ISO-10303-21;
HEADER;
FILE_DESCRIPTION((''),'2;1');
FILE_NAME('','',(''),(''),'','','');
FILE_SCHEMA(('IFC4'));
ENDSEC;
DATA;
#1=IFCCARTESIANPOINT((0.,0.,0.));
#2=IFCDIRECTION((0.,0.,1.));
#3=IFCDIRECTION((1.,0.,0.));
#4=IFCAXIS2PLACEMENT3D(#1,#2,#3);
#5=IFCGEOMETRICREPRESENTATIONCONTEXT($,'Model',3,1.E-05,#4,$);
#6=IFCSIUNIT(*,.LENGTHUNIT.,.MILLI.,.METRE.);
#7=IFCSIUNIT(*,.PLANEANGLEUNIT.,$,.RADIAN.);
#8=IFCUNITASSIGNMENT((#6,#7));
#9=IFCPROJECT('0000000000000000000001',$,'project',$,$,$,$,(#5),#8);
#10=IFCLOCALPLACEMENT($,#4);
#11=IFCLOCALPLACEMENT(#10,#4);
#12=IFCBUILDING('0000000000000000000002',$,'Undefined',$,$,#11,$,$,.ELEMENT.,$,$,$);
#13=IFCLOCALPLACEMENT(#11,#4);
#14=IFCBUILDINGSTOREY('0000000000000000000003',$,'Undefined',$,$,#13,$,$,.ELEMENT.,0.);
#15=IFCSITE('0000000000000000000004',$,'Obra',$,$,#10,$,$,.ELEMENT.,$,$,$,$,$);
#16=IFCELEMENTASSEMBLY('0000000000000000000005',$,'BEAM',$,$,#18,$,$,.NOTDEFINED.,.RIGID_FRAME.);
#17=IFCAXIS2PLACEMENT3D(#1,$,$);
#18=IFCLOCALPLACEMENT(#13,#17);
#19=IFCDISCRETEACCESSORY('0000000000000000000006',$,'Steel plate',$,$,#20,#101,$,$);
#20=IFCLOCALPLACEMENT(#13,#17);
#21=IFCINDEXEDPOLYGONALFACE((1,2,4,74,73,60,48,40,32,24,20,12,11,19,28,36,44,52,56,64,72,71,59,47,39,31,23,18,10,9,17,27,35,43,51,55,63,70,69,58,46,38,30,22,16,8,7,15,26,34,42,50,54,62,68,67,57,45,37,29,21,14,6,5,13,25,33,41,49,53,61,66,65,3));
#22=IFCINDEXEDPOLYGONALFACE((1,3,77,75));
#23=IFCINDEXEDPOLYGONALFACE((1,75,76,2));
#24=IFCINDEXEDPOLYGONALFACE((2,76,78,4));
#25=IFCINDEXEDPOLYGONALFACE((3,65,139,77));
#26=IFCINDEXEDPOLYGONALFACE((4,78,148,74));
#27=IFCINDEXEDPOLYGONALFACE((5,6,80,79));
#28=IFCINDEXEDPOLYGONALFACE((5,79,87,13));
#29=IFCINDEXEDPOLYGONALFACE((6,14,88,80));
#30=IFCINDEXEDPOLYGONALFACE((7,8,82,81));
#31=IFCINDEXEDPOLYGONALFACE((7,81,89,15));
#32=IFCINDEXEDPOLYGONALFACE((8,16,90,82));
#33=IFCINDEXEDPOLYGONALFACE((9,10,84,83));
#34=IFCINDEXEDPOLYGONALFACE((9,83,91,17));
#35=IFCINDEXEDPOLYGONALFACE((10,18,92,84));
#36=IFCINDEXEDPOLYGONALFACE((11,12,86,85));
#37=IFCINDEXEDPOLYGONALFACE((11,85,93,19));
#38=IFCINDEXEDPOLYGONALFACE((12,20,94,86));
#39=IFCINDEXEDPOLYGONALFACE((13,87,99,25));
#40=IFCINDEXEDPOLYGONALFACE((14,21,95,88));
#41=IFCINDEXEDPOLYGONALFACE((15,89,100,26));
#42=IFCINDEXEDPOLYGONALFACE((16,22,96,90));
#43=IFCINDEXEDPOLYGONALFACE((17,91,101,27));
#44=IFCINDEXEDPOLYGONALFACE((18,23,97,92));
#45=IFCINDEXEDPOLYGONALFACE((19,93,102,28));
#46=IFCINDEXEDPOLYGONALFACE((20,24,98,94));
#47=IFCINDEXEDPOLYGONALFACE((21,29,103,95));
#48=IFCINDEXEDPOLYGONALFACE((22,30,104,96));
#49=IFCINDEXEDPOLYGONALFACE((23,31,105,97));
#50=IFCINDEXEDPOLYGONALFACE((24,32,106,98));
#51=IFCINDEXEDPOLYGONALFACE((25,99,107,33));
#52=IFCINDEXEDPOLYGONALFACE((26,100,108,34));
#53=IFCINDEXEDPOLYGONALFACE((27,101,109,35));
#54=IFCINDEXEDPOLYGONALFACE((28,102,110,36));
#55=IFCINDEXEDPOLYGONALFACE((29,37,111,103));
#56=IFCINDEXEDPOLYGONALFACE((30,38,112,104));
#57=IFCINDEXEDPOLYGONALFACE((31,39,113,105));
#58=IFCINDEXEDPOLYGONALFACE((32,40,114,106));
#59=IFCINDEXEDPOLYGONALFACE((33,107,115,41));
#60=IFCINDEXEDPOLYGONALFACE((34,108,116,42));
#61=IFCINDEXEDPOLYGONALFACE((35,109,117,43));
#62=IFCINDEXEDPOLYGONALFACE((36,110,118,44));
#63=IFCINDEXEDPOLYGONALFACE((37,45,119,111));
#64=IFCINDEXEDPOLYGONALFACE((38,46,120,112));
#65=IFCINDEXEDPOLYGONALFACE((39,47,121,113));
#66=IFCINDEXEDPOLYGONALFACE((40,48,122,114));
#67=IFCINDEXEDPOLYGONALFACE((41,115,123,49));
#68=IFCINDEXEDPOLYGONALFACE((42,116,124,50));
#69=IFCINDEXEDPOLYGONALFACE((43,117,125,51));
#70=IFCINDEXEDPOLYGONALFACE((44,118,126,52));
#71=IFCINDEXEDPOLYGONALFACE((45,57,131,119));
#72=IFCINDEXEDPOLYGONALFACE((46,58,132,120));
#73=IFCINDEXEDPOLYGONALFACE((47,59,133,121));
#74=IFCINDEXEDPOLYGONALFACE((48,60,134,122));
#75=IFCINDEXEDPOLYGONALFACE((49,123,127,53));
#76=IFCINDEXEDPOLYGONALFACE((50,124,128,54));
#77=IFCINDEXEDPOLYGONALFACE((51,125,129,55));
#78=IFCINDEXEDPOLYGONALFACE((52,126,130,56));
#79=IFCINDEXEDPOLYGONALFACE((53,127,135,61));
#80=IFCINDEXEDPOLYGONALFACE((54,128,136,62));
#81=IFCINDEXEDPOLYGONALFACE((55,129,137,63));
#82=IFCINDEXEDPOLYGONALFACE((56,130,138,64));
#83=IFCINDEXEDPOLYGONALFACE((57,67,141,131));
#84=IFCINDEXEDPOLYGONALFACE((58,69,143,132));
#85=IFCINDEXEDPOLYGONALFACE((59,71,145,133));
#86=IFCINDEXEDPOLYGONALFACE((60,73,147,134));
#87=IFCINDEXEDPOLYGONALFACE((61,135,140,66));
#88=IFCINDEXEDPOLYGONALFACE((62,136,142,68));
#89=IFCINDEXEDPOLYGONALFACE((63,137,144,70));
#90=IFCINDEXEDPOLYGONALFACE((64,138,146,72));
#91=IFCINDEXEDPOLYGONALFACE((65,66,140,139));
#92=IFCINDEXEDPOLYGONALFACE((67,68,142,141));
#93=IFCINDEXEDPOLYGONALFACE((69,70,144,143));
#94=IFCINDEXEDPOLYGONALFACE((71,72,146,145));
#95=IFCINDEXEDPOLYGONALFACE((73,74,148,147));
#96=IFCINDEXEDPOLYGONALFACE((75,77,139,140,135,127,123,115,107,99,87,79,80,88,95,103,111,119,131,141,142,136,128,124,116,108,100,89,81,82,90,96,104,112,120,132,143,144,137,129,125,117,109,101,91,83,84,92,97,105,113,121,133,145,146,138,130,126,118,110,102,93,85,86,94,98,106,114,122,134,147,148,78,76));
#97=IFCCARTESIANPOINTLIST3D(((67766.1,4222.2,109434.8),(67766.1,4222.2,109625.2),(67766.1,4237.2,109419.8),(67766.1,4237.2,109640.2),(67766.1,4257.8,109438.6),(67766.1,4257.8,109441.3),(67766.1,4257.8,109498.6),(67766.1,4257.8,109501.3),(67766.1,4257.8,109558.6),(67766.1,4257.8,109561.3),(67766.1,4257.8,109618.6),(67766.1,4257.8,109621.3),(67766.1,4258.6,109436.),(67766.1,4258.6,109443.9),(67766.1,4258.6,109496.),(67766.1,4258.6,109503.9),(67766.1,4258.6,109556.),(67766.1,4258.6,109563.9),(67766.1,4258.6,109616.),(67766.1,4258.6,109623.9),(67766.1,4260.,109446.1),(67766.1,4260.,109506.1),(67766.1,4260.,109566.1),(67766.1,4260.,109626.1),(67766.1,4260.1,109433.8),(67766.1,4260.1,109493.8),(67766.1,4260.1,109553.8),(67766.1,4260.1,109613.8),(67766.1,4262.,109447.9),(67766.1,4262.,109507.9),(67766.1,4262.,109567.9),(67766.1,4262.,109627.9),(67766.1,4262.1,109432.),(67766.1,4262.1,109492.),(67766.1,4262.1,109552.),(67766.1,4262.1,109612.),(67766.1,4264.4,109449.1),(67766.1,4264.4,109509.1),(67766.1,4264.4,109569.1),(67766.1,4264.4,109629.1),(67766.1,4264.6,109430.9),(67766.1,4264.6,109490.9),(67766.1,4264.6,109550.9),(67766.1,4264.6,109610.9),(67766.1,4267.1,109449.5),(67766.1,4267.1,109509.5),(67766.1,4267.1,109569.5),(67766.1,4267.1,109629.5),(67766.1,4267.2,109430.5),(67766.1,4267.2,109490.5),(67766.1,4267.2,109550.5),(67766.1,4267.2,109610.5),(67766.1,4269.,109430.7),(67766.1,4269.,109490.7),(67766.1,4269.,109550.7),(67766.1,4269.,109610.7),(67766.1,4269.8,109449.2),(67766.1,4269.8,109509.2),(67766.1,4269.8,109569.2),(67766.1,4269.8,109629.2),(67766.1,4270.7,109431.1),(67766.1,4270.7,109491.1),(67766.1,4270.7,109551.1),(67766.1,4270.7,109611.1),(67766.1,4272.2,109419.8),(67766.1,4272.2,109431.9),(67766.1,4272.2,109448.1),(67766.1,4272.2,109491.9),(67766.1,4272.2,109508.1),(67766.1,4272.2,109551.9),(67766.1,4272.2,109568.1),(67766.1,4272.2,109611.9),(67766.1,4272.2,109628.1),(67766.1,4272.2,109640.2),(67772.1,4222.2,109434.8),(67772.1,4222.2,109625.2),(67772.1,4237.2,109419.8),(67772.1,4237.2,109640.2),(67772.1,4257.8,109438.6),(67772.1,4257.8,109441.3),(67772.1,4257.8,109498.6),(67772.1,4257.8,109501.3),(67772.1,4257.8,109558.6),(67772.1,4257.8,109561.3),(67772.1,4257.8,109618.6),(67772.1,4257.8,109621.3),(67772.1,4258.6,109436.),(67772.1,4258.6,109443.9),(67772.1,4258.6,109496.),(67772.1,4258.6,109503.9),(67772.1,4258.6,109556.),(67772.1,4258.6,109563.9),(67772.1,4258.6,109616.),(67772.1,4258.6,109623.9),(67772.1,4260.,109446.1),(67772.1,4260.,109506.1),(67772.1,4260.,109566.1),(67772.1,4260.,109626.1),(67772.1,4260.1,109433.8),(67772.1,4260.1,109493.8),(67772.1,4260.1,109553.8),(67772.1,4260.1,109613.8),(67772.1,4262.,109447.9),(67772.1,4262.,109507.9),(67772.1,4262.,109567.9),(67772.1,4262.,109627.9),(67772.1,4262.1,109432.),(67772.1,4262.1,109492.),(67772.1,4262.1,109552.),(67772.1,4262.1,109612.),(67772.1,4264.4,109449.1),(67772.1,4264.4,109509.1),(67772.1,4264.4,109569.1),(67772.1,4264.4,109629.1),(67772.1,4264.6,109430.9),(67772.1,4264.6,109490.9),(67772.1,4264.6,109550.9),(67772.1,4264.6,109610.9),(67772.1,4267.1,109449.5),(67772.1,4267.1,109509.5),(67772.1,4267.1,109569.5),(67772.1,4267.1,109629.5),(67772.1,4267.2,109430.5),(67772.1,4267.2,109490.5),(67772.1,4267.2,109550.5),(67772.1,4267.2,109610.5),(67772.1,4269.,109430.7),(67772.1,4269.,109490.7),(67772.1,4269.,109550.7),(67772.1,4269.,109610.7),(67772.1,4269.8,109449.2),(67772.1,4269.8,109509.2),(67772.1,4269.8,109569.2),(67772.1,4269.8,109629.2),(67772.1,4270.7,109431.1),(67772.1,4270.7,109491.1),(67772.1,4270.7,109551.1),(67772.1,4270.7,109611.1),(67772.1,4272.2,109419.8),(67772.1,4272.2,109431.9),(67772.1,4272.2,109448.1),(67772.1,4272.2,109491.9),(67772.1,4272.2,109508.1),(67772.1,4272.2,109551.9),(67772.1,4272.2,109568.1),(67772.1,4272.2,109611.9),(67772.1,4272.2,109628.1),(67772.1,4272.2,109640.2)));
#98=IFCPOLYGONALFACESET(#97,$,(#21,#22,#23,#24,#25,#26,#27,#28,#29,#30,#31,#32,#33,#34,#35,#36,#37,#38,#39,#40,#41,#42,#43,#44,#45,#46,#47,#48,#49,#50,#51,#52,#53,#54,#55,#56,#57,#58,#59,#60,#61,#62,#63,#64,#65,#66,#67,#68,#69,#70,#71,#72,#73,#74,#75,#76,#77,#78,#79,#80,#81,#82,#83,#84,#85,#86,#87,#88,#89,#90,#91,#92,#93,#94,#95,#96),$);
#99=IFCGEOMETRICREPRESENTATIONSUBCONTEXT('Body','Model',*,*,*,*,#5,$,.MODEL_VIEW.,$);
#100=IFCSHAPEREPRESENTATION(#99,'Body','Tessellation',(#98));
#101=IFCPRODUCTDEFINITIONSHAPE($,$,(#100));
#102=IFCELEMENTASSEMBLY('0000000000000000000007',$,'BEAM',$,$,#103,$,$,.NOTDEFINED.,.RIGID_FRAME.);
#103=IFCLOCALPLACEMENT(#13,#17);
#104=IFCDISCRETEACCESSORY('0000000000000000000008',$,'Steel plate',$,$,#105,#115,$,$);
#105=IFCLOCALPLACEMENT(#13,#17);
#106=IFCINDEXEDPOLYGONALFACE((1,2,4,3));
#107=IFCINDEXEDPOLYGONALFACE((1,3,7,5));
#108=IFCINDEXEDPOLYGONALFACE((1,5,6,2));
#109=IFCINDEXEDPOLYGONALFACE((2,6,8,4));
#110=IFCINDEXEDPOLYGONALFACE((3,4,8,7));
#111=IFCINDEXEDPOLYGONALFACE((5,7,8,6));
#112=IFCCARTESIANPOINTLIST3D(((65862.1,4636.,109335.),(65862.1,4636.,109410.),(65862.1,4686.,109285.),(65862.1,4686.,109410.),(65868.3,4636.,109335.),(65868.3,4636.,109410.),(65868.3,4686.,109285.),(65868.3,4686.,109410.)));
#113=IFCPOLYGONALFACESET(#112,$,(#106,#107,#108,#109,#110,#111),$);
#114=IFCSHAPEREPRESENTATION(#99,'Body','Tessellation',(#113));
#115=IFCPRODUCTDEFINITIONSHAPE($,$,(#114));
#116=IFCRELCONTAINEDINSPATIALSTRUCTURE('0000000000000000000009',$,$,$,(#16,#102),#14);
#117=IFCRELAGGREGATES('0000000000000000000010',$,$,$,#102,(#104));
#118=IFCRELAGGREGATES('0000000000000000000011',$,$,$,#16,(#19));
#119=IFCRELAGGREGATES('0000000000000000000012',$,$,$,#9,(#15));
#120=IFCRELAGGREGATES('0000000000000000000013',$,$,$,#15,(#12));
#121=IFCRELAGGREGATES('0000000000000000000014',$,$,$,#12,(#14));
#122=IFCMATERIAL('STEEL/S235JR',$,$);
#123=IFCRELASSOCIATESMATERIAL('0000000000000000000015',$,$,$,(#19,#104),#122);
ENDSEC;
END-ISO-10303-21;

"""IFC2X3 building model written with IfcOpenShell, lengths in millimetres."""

from ifc_helpers import new_model, si_unit, frame, origin_with_axes, origin_2d_with_axis, place, context, subcontext, project, spatial, polyline, circle, outline, extrude, source, transform, mapped, material, element, aggregate, save


model = new_model("IFC2X3")

# Units and contexts
model_context = context("Model", 3, precision=1e-05, world=origin_with_axes())
body_context = subcontext(model_context, "Body", "Model", "MODEL_VIEW")
ifc_project = project(units=[si_unit("LENGTHUNIT", "METRE", prefix="MILLI"), si_unit("PLANEANGLEUNIT", "RADIAN")], contexts=[model_context])

# Site, building, storey
site_placement = place(None, origin_with_axes())
site = spatial("IfcSite", under=ifc_project, at=site_placement, Name="Obra", CompositionType="ELEMENT")
building_placement = place(site_placement, origin_with_axes())
building = spatial("IfcBuilding", under=site, at=building_placement, Name="Undefined", CompositionType="ELEMENT")
storey_placement = place(building_placement, origin_with_axes())
storey = spatial("IfcBuildingStorey", under=building, at=storey_placement, Name="Undefined", CompositionType="ELEMENT", Elevation=0.0)

# Shared definitions
ifc_material_1 = material(Name="STEEL/S235JR")

# Shared definitions
shared_shape_1 = source(origin_with_axes(), body_context, "Body", "SweptSolid", [
    extrude(circle(Radius=9.5, at=origin_2d_with_axis()), frame((0.0, -9.2, 0.0), z_axis=(0.0, 1.0, 0.0), x_axis=(1.0, 0.0, 0.0)), (0.0, 0.0, 1.0), 6.2),
])

# Element assembly, discrete accessory, opening
assembly_1_placement = place(storey_placement, origin_with_axes())
assembly_1 = element("IfcElementAssembly", 1, at=assembly_1_placement, inside=storey, Name="BEAM", AssemblyPlace="NOTDEFINED", PredefinedType="RIGID_FRAME")
discrete_accessory_1_placement = place(assembly_1_placement, frame((67769.1, 4272.2, 109419.8), z_axis=(-1.0, 0.0, 0.0), x_axis=(0.0, -1.0, 0.0)))
discrete_accessory_1 = element("IfcDiscreteAccessory", 2, at=discrete_accessory_1_placement, material=ifc_material_1, Name="Steel plate", context=body_context, shape_type="SweptSolid", body=[
    extrude(outline(polyline([(0.0, 0.0), (35.0, 0.0), (50.0, 15.0), (50.0, 205.4), (35.0, 220.4), (0.0, 220.4), (0.0, 0.0)])), frame((0.0, 0.0, -3.0), z_axis=(0.0, 0.0, 1.0), x_axis=(1.0, 0.0, 0.0)), (0.0, 0.0, 1.0), 6.0),
])
opening_1_placement = place(assembly_1_placement, frame((67763.0, 4232.2, 109650.0), z_axis=(0.0, 1.0, 0.0), x_axis=(0.0, 0.0, -1.0)))
element("IfcOpeningElement", 3, at=opening_1_placement, cuts=discrete_accessory_1, ObjectType="Opening", context=body_context, shape_type="MappedRepresentation", body=[
    mapped(shared_shape_1, transform((30.0, 0.0, 35.0))),
    mapped(shared_shape_1, transform((90.0, 0.0, 35.0))),
    mapped(shared_shape_1, transform((150.0, 0.0, 35.0))),
    mapped(shared_shape_1, transform((210.0, 0.0, 35.0))),
])

# Element assembly, discrete accessory
assembly_2_placement = place(storey_placement, origin_with_axes())
assembly_2 = element("IfcElementAssembly", 4, at=assembly_2_placement, inside=storey, Name="BEAM", AssemblyPlace="NOTDEFINED", PredefinedType="RIGID_FRAME")
discrete_accessory_2_placement = place(assembly_2_placement, frame((65865.2, 4686.0, 109410.0), z_axis=(-1.0, 0.0, 0.0), x_axis=(0.0, 0.0, -1.0)))
discrete_accessory_2 = element("IfcDiscreteAccessory", 5, at=discrete_accessory_2_placement, material=ifc_material_1, Name="Steel plate", context=body_context, shape_type="SweptSolid", body=[
    extrude(outline(polyline([(0.0, 0.0), (150.0, 0.0), (150.0, -25.0), (75.0, 50.0), (0.0, 50.0), (0.0, 0.0)])), frame((0.0, 0.0, -3.1), z_axis=(0.0, 0.0, 1.0), x_axis=(1.0, 0.0, 0.0)), (0.0, 0.0, 1.0), 6.2),
])

aggregate(assembly_2, [discrete_accessory_2])

aggregate(assembly_1, [discrete_accessory_1])

save(model, "model.ifc")
